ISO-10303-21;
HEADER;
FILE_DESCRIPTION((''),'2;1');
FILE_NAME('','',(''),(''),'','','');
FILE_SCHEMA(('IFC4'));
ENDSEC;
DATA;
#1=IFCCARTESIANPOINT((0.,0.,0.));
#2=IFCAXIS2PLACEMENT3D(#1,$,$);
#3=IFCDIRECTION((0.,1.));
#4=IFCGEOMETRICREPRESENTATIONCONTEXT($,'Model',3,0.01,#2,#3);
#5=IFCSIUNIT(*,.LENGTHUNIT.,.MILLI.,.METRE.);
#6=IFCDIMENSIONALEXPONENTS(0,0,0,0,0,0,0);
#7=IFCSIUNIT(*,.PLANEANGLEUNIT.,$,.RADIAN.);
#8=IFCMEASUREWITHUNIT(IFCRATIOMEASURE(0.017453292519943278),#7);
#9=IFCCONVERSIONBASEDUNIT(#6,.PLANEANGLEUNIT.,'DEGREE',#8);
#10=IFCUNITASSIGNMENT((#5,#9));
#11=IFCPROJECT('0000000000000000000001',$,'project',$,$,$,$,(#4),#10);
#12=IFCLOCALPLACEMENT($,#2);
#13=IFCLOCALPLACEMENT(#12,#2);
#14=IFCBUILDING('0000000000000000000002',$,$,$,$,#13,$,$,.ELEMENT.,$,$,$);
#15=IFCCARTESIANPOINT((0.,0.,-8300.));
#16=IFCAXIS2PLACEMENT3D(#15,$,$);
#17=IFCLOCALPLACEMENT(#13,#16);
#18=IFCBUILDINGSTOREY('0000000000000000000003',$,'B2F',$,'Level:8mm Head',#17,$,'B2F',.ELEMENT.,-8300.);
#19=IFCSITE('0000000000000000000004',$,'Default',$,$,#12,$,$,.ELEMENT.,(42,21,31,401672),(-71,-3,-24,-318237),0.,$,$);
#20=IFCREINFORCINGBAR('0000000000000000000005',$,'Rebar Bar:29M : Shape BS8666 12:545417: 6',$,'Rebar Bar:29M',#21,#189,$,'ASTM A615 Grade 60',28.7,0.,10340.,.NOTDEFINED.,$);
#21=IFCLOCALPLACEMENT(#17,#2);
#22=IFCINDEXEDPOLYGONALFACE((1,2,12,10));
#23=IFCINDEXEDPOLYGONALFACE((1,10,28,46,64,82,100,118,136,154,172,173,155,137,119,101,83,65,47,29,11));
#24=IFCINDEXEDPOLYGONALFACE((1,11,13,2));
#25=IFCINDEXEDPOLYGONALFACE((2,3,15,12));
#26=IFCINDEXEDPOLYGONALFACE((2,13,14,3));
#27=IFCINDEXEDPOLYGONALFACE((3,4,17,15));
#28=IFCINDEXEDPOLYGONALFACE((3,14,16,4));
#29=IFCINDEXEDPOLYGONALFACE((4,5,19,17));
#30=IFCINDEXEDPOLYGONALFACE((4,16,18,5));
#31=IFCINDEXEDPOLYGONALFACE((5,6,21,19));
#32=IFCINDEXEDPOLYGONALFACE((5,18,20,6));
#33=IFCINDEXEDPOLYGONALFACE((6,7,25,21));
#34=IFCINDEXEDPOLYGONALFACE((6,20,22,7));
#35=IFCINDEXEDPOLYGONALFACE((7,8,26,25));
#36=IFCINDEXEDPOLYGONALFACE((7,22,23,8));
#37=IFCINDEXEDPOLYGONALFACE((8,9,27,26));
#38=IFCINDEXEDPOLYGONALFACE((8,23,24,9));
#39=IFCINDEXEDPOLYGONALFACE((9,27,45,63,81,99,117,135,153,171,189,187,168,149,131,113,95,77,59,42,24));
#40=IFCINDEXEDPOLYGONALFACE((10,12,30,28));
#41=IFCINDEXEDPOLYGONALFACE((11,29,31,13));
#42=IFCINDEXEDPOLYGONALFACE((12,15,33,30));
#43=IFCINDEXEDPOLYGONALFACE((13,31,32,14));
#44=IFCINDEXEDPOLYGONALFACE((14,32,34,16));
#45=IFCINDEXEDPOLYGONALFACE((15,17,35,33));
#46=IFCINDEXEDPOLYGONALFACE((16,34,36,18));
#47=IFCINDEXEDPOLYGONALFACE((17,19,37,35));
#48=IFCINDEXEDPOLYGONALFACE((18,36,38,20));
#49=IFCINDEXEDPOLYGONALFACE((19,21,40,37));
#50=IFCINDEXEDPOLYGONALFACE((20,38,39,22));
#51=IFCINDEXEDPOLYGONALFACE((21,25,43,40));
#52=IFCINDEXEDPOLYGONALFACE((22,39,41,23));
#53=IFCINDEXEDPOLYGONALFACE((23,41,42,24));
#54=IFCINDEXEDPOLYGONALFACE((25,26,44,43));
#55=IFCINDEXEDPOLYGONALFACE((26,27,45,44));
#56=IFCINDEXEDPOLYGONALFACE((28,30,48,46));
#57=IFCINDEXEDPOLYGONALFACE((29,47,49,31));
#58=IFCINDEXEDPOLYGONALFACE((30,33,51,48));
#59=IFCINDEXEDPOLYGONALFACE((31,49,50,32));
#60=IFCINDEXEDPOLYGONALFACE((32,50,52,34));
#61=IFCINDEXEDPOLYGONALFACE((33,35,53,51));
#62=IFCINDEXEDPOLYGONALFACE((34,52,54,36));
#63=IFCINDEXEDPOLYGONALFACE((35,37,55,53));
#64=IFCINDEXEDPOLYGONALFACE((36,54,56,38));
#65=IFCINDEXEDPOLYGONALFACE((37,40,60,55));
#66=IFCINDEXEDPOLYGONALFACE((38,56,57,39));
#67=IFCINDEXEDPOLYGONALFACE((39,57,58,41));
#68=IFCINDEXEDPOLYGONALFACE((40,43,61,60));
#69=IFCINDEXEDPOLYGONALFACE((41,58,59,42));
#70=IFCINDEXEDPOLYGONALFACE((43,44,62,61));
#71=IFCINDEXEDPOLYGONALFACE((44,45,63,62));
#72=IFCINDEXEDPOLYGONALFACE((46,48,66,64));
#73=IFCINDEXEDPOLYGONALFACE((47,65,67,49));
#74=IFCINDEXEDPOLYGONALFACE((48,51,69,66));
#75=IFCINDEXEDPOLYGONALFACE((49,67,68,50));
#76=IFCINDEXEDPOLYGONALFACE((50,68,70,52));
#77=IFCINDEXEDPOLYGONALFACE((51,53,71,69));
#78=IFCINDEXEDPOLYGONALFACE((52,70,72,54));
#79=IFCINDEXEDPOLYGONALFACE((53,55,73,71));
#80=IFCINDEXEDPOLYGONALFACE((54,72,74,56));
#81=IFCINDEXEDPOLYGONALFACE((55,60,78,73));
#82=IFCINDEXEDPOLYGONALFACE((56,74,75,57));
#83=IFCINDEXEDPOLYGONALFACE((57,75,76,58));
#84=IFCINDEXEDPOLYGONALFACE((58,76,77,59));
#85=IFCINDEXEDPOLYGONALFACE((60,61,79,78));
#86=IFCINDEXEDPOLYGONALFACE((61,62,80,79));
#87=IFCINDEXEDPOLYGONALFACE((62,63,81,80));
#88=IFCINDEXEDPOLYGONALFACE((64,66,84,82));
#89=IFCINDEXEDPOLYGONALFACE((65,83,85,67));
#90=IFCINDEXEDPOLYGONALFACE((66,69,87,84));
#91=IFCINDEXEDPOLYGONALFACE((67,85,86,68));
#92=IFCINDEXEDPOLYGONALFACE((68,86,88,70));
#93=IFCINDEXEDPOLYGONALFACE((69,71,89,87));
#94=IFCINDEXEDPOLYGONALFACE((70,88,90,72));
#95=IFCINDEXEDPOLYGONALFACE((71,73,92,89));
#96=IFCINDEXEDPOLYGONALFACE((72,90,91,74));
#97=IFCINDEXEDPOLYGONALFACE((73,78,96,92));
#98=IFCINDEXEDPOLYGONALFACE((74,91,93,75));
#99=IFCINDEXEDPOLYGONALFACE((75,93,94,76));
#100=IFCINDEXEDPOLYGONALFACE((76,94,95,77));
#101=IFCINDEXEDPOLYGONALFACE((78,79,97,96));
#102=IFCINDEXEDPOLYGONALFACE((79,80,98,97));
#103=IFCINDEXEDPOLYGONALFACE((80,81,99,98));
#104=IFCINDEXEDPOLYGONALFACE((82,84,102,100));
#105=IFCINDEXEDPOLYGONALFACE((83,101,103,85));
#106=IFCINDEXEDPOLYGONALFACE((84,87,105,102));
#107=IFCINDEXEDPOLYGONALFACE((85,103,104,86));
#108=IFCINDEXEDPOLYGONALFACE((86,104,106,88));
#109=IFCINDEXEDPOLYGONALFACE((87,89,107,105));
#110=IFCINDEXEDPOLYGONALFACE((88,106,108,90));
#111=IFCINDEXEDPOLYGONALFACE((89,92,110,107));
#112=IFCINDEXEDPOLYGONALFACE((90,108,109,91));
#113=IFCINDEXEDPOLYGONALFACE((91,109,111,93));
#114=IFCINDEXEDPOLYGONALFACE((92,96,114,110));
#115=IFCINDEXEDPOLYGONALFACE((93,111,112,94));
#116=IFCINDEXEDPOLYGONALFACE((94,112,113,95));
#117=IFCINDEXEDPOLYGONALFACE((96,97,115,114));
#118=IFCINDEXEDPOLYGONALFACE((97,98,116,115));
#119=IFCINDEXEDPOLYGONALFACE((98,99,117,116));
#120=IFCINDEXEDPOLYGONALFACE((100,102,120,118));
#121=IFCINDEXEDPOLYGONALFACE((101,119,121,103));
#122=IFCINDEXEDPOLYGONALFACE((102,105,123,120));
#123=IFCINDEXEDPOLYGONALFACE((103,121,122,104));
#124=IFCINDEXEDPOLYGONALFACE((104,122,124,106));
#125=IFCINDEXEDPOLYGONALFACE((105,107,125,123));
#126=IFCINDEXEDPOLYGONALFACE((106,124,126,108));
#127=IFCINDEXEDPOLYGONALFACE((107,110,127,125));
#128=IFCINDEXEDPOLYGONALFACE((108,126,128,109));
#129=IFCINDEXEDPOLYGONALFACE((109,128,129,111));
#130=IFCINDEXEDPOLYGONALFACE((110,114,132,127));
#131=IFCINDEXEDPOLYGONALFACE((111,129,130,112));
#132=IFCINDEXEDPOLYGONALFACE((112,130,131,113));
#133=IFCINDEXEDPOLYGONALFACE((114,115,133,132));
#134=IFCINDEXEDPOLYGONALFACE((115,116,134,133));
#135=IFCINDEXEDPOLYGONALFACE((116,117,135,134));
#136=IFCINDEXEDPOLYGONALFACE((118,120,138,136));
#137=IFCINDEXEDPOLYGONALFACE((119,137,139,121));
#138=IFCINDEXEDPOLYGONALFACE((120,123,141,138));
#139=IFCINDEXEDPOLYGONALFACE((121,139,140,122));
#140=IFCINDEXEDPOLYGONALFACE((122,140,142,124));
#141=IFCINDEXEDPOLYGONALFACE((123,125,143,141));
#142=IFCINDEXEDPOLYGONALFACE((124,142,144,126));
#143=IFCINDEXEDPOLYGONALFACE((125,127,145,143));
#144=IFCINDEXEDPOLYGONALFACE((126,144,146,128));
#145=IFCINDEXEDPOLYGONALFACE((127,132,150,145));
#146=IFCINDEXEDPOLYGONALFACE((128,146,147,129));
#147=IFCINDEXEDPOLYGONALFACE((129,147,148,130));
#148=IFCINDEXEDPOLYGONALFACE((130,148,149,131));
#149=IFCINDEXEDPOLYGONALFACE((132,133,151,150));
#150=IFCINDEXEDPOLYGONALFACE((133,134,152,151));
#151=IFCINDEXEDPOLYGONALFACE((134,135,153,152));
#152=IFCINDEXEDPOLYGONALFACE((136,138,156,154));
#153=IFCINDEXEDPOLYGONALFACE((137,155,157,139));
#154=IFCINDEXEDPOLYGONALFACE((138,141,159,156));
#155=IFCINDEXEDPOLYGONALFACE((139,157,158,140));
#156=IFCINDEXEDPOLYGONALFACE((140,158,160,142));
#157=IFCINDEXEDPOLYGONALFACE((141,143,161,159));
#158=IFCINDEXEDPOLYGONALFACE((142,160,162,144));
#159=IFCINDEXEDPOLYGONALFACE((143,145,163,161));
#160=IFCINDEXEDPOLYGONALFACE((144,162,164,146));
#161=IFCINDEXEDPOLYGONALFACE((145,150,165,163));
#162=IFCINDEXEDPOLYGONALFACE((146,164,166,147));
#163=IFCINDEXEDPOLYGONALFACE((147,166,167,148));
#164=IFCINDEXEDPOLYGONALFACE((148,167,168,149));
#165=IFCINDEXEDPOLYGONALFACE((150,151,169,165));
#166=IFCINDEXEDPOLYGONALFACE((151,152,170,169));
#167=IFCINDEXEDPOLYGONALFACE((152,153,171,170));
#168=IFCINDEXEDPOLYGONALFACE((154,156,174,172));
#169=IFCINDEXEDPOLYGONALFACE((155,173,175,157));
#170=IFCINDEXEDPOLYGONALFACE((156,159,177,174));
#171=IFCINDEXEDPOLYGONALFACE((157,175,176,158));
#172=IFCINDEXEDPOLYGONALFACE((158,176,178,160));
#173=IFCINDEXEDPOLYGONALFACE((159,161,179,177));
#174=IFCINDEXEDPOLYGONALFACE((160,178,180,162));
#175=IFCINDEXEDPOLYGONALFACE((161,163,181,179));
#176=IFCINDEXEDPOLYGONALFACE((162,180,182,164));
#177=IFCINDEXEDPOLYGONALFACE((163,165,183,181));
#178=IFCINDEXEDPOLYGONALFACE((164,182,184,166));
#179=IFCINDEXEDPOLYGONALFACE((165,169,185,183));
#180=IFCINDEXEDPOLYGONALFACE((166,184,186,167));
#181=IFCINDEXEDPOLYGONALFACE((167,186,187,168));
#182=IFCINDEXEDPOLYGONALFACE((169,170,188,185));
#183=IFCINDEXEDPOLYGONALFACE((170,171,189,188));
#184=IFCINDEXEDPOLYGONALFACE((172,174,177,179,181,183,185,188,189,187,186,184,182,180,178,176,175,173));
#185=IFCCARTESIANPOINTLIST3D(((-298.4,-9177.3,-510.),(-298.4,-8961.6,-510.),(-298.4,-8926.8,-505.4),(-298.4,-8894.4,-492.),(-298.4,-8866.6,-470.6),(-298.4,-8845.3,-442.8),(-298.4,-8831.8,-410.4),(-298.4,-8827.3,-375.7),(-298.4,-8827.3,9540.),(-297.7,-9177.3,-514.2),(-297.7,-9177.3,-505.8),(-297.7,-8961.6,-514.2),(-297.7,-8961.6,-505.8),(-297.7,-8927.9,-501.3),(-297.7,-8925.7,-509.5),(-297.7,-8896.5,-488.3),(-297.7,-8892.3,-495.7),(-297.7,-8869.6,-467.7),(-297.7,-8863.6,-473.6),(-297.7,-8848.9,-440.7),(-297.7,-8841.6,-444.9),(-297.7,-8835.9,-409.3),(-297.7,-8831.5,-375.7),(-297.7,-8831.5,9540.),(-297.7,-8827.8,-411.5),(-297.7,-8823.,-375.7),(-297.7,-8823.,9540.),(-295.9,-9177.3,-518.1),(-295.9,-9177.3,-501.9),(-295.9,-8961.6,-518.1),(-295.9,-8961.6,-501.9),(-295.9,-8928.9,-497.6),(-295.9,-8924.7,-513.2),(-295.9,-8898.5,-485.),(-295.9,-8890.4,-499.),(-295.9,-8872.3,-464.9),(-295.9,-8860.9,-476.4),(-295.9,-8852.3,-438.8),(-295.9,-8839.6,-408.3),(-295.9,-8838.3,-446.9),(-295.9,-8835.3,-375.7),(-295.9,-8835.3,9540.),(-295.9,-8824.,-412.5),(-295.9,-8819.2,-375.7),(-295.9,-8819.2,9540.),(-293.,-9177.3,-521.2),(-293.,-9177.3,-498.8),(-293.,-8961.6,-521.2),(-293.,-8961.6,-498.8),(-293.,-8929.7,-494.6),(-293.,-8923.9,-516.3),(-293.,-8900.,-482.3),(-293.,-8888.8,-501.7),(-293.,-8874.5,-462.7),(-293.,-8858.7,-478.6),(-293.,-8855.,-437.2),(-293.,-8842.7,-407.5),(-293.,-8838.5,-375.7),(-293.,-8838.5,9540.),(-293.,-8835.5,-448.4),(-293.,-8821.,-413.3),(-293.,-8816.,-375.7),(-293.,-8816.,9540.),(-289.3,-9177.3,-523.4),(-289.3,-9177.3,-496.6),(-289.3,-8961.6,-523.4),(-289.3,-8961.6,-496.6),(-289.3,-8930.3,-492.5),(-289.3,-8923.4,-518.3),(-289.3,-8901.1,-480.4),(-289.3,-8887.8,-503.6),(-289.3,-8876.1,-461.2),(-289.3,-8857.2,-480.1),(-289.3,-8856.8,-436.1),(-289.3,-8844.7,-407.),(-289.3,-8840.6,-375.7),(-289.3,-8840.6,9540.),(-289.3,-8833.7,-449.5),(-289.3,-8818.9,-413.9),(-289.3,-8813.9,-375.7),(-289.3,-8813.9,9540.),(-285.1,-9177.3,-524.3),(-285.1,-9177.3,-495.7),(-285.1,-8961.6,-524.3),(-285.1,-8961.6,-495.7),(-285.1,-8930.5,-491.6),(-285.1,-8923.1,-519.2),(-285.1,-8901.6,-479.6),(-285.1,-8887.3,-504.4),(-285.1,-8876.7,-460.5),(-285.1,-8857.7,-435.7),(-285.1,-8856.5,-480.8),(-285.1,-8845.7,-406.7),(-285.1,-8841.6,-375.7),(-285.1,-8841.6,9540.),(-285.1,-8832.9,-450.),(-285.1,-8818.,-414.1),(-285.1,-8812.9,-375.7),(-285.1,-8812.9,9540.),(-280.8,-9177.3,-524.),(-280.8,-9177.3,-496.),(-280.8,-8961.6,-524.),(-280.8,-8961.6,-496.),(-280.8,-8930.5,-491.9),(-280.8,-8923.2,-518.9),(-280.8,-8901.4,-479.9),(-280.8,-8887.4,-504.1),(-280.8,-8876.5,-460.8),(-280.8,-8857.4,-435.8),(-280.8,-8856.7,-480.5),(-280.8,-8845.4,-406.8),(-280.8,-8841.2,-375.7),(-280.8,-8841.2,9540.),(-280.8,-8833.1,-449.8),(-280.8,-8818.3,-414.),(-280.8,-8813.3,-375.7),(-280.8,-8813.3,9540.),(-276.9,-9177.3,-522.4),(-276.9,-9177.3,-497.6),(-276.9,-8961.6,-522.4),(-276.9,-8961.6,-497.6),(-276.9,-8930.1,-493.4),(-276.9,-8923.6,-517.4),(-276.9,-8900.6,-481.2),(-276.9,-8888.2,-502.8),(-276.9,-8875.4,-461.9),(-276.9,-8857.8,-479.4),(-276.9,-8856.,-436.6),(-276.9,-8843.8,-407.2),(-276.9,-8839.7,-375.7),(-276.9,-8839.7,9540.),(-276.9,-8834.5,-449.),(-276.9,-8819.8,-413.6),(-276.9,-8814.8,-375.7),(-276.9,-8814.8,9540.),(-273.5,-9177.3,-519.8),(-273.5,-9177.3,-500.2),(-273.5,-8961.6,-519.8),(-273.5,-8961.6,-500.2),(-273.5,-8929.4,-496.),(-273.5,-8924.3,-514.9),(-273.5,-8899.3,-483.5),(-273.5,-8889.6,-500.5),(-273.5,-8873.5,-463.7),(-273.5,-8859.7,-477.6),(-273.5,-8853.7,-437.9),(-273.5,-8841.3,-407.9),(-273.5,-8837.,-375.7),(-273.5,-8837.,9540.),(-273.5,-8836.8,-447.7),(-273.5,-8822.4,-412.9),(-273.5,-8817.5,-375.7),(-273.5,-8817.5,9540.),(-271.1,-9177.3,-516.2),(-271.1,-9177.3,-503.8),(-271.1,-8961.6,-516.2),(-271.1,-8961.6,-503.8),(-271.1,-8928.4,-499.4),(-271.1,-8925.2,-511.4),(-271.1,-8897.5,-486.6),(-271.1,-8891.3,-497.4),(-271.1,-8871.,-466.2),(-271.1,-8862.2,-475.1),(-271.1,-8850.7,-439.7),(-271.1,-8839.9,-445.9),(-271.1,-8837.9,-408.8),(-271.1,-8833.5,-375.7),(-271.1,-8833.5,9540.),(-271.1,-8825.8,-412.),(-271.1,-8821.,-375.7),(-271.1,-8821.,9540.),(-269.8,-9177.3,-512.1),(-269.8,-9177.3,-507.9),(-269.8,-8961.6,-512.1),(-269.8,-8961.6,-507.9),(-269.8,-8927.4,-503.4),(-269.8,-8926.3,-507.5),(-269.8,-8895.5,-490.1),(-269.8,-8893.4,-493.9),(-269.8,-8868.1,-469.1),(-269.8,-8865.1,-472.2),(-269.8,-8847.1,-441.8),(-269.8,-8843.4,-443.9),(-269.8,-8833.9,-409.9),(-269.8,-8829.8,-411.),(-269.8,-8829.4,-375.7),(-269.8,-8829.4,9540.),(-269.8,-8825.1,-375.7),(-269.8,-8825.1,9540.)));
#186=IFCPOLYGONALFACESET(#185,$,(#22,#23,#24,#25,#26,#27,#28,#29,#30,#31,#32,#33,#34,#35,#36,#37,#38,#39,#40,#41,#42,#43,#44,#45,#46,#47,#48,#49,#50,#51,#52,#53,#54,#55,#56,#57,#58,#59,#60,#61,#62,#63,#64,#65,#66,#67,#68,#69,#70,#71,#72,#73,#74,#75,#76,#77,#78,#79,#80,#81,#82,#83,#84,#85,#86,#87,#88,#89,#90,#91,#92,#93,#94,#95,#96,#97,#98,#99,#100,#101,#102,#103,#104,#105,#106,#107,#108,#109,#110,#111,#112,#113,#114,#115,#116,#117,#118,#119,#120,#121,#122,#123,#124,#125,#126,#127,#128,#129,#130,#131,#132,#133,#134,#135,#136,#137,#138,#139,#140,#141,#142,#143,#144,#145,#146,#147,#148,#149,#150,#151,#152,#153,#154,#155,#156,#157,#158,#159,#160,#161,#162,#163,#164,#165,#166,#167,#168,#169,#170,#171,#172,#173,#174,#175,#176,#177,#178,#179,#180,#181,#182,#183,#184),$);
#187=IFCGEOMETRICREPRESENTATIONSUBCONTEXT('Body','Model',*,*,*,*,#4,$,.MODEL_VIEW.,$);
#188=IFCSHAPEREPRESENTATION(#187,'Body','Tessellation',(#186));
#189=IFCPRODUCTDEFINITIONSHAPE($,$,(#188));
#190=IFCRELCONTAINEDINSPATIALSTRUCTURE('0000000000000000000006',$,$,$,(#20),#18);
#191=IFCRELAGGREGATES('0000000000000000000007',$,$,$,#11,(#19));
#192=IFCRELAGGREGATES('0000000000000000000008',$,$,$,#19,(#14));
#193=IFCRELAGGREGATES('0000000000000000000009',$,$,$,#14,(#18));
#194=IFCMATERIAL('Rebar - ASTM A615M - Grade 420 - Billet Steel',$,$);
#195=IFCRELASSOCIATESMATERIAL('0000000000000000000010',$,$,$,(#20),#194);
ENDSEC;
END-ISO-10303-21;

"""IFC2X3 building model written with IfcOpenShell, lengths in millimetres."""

from ifc_helpers import new_model, entity, si_unit, converted_unit, direction, frame, origin, place, context, subcontext, project, spatial, material, element, save


model = new_model("IFC2X3")

# Units and contexts
model_context = context("Model", 3, precision=0.01, world=origin(), true_north=direction((0.0, 1.0)))
body_context = subcontext(model_context, "Body", "Model", "MODEL_VIEW")
ifc_project = project(units=[si_unit("LENGTHUNIT", "METRE", prefix="MILLI"), converted_unit("PLANEANGLEUNIT", "DEGREE", entity("IfcRatioMeasure", 0.017453292519943278), si_unit("PLANEANGLEUNIT", "RADIAN"), dimensions=[0, 0, 0, 0, 0, 0, 0])], contexts=[model_context])

# Site, building, storey
site_placement = place(None, origin())
site = spatial("IfcSite", under=ifc_project, at=site_placement, Name="Default", CompositionType="ELEMENT", RefLatitude=(42, 21, 31, 401672), RefLongitude=(-71, -3, -24, -318237), RefElevation=0.0)
building_placement = place(site_placement, origin())
building = spatial("IfcBuilding", under=site, at=building_placement, CompositionType="ELEMENT")
storey_placement = place(building_placement, frame((0.0, 0.0, -8300.0)))
storey = spatial("IfcBuildingStorey", under=building, at=storey_placement, Name="B2F", ObjectType="Level:8mm Head", LongName="B2F", CompositionType="ELEMENT", Elevation=-8300.0)

# Reinforcing bar
ifc_material_1 = material(Name="Rebar - ASTM A615M - Grade 420 - Billet Steel")
reinforcing_bar_1_placement = place(storey_placement, origin())
element("IfcReinforcingBar", 1, at=reinforcing_bar_1_placement, inside=storey, material=ifc_material_1, Name="Rebar Bar:29M : Shape BS8666 12:545417: 6", SteelGrade="ASTM A615 Grade 60", ObjectType="Rebar Bar:29M", BarLength=10340.0, BarRole="NOTDEFINED", CrossSectionArea=0.0, NominalDiameter=28.7, context=body_context, shape_type="AdvancedSweptSolid", body=[
    entity("IfcSweptDiskSolid", entity("IfcCompositeCurve", [entity("IfcCompositeCurveSegment", "CONTINUOUS", True, entity("IfcPolyline", [entity("IfcCartesianPoint", [-284.0, -8827.3, 9540.0]), entity("IfcCartesianPoint", [-284.0, -8827.3, -375.7])])), entity("IfcCompositeCurveSegment", "CONTINUOUS", True, entity("IfcTrimmedCurve", entity("IfcCircle", entity("IfcAxis2Placement3D", entity("IfcCartesianPoint", [-284.0, -8961.6, -375.7]), entity("IfcDirection", [-1.0, 0.0, 0.0]), entity("IfcDirection", [0.0, 0.0, -1.0])), 134.3), [entity("IfcParameterValue", 270.0)], [entity("IfcParameterValue", 360.0)], True, "PARAMETER")), entity("IfcCompositeCurveSegment", "CONTINUOUS", True, entity("IfcPolyline", [entity("IfcCartesianPoint", [-284.0, -8961.6, -510.0]), entity("IfcCartesianPoint", [-284.0, -9177.3, -510.0])]))], False), 14.3, None, 0.0, 92.0),
])

save(model, "model.ifc")
